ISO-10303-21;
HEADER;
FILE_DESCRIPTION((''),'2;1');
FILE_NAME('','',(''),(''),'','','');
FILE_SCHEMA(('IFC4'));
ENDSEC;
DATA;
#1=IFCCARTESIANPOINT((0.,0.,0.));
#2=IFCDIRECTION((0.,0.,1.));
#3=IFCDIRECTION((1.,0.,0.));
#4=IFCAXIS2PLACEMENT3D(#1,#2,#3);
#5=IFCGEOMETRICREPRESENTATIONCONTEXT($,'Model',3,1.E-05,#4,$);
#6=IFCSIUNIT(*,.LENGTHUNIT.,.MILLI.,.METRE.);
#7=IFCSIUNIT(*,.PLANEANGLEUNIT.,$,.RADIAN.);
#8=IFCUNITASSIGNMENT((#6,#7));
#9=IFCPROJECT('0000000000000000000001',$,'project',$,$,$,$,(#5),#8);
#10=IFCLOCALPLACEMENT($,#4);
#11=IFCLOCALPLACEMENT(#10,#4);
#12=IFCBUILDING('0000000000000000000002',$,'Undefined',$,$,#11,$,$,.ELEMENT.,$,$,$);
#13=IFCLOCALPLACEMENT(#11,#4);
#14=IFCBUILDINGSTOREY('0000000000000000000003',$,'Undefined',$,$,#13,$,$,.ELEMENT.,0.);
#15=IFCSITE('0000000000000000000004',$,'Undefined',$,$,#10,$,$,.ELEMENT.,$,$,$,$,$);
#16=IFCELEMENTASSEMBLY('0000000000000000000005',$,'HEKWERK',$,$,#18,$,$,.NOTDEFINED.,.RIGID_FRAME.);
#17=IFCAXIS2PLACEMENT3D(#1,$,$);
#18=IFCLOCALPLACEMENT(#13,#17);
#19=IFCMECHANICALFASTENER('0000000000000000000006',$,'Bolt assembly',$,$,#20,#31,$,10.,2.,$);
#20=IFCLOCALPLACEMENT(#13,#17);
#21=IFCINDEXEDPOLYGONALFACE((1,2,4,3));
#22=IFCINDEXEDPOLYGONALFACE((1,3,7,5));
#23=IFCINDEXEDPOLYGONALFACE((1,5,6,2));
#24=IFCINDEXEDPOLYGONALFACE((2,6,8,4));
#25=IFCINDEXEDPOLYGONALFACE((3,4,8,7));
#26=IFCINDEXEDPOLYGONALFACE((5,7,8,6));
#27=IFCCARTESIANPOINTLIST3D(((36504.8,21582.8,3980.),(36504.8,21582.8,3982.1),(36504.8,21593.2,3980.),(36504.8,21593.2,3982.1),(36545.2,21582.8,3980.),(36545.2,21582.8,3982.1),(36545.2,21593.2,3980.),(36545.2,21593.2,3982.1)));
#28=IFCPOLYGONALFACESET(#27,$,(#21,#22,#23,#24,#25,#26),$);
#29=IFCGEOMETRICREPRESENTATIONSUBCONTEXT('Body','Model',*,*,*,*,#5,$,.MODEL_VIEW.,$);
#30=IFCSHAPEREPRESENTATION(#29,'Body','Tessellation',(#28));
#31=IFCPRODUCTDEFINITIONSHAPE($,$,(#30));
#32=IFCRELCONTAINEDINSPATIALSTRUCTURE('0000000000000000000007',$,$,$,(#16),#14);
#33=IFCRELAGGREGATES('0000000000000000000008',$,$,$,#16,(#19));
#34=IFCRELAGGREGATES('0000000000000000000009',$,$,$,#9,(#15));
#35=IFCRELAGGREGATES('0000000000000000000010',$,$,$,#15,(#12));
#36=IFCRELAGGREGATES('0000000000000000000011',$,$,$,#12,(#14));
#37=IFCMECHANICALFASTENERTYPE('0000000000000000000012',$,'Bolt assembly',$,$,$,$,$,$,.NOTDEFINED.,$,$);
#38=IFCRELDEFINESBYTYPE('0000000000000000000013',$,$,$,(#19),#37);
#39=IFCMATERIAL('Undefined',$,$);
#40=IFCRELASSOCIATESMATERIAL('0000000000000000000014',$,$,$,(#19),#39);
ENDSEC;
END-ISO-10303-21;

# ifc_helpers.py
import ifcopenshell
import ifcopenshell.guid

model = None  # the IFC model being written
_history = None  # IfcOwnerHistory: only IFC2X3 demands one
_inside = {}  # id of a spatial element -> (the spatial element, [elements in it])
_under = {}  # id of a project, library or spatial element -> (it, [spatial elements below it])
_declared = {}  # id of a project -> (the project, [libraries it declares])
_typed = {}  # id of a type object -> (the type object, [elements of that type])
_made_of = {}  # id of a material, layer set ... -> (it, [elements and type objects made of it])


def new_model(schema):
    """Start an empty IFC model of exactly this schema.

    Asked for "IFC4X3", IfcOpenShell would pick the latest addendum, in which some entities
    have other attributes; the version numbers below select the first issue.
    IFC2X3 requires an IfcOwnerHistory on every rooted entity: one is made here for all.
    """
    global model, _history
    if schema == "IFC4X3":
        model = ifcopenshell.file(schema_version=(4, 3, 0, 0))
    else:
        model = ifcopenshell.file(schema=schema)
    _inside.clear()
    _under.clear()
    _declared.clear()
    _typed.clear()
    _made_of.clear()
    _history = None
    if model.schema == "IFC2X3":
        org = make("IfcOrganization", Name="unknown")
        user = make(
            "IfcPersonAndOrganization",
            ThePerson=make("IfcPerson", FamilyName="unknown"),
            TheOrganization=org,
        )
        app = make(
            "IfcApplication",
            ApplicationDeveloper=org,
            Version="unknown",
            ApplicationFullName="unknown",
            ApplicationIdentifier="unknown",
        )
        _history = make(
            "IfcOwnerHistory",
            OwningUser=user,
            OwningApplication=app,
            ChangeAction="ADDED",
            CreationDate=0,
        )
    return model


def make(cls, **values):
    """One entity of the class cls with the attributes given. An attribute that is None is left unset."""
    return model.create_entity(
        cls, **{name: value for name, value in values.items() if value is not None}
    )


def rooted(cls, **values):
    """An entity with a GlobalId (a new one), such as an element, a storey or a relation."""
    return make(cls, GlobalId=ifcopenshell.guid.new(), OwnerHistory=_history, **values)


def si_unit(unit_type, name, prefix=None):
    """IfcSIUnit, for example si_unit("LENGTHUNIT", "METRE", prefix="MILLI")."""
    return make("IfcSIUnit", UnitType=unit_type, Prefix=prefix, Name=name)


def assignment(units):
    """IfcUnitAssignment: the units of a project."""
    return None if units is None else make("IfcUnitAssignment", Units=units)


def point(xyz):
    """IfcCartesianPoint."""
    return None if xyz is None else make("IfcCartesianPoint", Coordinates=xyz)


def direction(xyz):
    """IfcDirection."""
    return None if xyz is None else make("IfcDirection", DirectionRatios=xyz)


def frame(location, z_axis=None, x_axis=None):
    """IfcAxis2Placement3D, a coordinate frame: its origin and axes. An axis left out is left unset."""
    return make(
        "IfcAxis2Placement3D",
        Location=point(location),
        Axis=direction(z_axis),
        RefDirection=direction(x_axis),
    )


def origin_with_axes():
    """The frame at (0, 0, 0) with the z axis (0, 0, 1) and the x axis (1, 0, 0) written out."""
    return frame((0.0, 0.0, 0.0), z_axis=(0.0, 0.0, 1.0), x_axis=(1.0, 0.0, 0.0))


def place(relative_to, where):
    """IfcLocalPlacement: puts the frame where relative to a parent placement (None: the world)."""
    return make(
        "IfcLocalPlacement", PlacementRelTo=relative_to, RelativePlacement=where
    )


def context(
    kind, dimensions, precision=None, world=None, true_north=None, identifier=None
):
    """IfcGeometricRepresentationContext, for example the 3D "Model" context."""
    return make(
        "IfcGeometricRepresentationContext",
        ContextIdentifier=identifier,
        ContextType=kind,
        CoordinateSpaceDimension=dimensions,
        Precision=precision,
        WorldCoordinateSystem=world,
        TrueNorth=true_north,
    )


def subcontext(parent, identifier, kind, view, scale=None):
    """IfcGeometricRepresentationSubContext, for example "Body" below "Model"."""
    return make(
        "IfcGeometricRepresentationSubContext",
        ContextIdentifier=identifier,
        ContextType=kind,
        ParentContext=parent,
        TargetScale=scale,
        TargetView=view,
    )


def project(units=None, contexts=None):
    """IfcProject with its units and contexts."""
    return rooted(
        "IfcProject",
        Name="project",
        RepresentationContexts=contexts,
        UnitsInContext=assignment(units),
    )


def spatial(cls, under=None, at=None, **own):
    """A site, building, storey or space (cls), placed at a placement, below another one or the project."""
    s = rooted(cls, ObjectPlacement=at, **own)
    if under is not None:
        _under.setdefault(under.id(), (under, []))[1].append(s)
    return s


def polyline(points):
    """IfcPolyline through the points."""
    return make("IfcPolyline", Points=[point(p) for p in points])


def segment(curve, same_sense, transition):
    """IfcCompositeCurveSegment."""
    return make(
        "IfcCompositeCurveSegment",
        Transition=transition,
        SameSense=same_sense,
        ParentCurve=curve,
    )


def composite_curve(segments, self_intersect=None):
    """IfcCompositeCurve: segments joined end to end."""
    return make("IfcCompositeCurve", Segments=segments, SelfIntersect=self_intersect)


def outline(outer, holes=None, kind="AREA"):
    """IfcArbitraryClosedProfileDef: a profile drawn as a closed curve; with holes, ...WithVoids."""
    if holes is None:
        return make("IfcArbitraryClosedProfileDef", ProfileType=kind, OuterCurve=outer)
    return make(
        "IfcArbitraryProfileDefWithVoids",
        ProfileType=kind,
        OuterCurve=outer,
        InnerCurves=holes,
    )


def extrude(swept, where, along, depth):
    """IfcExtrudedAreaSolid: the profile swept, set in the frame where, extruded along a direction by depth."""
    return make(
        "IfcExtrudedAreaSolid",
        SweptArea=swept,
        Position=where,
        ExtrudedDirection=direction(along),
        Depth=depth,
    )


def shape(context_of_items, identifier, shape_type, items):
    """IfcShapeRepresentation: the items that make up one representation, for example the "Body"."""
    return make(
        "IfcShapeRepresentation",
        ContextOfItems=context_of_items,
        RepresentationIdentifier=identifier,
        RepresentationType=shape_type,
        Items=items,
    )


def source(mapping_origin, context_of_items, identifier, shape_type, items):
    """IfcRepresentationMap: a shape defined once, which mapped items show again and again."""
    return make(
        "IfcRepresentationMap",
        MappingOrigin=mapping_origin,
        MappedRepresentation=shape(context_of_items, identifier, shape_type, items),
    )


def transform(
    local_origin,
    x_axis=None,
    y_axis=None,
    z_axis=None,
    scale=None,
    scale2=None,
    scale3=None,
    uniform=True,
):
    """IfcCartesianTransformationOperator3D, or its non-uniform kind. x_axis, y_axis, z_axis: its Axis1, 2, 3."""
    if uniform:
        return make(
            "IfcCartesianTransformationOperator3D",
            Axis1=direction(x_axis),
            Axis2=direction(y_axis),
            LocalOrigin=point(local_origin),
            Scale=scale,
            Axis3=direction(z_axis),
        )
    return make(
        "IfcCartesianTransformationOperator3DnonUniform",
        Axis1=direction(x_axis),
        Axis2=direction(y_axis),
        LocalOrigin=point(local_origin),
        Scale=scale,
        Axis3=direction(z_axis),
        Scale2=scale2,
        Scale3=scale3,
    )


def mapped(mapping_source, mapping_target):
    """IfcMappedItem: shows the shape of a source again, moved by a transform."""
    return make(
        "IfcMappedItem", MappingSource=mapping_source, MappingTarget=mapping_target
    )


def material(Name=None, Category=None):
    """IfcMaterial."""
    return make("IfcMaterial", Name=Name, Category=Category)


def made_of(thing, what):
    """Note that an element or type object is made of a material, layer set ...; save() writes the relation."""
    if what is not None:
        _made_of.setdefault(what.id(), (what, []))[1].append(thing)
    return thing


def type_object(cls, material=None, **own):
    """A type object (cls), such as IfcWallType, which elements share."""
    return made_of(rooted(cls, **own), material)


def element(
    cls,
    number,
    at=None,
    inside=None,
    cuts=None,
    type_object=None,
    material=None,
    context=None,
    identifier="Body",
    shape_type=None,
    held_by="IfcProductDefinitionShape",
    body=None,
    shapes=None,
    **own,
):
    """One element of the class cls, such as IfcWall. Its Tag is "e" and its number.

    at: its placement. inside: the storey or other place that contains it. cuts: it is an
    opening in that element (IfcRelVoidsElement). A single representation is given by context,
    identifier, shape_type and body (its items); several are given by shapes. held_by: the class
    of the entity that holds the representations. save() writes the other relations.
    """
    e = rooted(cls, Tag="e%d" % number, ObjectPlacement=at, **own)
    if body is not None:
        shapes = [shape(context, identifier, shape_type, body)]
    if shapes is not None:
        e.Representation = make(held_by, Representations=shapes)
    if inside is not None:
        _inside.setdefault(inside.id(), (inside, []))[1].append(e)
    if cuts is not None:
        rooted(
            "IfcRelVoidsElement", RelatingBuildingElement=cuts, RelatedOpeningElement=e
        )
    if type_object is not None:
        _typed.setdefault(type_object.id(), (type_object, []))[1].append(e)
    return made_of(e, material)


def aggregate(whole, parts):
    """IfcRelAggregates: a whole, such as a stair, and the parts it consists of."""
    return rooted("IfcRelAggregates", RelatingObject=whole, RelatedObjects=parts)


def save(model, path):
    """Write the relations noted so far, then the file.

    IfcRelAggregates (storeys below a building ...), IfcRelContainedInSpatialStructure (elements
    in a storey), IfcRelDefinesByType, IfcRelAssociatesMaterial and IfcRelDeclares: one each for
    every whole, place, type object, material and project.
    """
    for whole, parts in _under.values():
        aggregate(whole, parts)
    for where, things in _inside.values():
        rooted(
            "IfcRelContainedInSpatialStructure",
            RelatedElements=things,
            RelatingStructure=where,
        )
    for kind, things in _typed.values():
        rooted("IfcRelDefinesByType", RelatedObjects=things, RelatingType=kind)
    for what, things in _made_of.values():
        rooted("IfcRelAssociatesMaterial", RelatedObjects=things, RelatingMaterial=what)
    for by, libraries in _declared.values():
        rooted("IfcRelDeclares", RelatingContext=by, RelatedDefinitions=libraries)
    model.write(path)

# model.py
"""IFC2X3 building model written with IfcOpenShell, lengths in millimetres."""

from ifc_helpers import new_model, si_unit, frame, origin_with_axes, place, context, subcontext, project, spatial, polyline, segment, composite_curve, outline, extrude, source, transform, mapped, material, type_object, element, aggregate, save


model = new_model("IFC2X3")

# Units and contexts
model_context = context("Model", 3, precision=1e-05, world=origin_with_axes())
body_context = subcontext(model_context, "Body", "Model", "MODEL_VIEW")
ifc_project = project(units=[si_unit("LENGTHUNIT", "METRE", prefix="MILLI"), si_unit("PLANEANGLEUNIT", "RADIAN")], contexts=[model_context])

# Site, building, storey
site_placement = place(None, origin_with_axes())
site = spatial("IfcSite", under=ifc_project, at=site_placement, Name="Undefined", CompositionType="ELEMENT")
building_placement = place(site_placement, origin_with_axes())
building = spatial("IfcBuilding", under=site, at=building_placement, Name="Undefined", CompositionType="ELEMENT")
storey_placement = place(building_placement, origin_with_axes())
storey = spatial("IfcBuildingStorey", under=building, at=storey_placement, Name="Undefined", CompositionType="ELEMENT", Elevation=0.0)

# Element assembly
assembly_1_placement = place(storey_placement, origin_with_axes())
assembly_1 = element("IfcElementAssembly", 1, at=assembly_1_placement, inside=storey, Name="HEKWERK", AssemblyPlace="NOTDEFINED", PredefinedType="RIGID_FRAME")

# Shared definitions
ifc_material_1 = material(Name="Undefined")
mechanical_fastener_type = type_object("IfcMechanicalFastenerType", Name="Bolt assembly")

# Mechanical fastener
shared_shape_1 = source(origin_with_axes(), body_context, "Body", "SweptSolid", [
    extrude(outline(composite_curve([segment(polyline([(-20.2, 5.2), (20.2, 5.2)]), True, "CONTINUOUS"), segment(polyline([(20.2, 5.2), (20.2, -5.2)]), True, "CONTINUOUS"), segment(polyline([(20.2, -5.2), (-20.2, -5.2)]), True, "CONTINUOUS"), segment(polyline([(-20.2, -5.2), (-20.2, 5.2)]), True, "CONTINUOUS")], self_intersect=False)), frame((0.0, -1.0, 0.0), z_axis=(0.0, 1.0, 0.0), x_axis=(1.0, 0.0, 0.0)), (0.0, 0.0, 1.0), 2.1),
])
mechanical_fastener_1_placement = place(assembly_1_placement, frame((36525.0, 21588.0, 3981.0), z_axis=(0.0, -1.0, 0.0), x_axis=(1.0, 0.0, 0.0)))
mechanical_fastener_1 = element("IfcMechanicalFastener", 2, at=mechanical_fastener_1_placement, type_object=mechanical_fastener_type, material=ifc_material_1, Name="Bolt assembly", NominalDiameter=10.0, NominalLength=2.0, context=body_context, shape_type="MappedRepresentation", body=[
    mapped(shared_shape_1, transform((0.0, 0.0, 0.0))),
])
aggregate(assembly_1, [mechanical_fastener_1])

save(model, "model.ifc")
